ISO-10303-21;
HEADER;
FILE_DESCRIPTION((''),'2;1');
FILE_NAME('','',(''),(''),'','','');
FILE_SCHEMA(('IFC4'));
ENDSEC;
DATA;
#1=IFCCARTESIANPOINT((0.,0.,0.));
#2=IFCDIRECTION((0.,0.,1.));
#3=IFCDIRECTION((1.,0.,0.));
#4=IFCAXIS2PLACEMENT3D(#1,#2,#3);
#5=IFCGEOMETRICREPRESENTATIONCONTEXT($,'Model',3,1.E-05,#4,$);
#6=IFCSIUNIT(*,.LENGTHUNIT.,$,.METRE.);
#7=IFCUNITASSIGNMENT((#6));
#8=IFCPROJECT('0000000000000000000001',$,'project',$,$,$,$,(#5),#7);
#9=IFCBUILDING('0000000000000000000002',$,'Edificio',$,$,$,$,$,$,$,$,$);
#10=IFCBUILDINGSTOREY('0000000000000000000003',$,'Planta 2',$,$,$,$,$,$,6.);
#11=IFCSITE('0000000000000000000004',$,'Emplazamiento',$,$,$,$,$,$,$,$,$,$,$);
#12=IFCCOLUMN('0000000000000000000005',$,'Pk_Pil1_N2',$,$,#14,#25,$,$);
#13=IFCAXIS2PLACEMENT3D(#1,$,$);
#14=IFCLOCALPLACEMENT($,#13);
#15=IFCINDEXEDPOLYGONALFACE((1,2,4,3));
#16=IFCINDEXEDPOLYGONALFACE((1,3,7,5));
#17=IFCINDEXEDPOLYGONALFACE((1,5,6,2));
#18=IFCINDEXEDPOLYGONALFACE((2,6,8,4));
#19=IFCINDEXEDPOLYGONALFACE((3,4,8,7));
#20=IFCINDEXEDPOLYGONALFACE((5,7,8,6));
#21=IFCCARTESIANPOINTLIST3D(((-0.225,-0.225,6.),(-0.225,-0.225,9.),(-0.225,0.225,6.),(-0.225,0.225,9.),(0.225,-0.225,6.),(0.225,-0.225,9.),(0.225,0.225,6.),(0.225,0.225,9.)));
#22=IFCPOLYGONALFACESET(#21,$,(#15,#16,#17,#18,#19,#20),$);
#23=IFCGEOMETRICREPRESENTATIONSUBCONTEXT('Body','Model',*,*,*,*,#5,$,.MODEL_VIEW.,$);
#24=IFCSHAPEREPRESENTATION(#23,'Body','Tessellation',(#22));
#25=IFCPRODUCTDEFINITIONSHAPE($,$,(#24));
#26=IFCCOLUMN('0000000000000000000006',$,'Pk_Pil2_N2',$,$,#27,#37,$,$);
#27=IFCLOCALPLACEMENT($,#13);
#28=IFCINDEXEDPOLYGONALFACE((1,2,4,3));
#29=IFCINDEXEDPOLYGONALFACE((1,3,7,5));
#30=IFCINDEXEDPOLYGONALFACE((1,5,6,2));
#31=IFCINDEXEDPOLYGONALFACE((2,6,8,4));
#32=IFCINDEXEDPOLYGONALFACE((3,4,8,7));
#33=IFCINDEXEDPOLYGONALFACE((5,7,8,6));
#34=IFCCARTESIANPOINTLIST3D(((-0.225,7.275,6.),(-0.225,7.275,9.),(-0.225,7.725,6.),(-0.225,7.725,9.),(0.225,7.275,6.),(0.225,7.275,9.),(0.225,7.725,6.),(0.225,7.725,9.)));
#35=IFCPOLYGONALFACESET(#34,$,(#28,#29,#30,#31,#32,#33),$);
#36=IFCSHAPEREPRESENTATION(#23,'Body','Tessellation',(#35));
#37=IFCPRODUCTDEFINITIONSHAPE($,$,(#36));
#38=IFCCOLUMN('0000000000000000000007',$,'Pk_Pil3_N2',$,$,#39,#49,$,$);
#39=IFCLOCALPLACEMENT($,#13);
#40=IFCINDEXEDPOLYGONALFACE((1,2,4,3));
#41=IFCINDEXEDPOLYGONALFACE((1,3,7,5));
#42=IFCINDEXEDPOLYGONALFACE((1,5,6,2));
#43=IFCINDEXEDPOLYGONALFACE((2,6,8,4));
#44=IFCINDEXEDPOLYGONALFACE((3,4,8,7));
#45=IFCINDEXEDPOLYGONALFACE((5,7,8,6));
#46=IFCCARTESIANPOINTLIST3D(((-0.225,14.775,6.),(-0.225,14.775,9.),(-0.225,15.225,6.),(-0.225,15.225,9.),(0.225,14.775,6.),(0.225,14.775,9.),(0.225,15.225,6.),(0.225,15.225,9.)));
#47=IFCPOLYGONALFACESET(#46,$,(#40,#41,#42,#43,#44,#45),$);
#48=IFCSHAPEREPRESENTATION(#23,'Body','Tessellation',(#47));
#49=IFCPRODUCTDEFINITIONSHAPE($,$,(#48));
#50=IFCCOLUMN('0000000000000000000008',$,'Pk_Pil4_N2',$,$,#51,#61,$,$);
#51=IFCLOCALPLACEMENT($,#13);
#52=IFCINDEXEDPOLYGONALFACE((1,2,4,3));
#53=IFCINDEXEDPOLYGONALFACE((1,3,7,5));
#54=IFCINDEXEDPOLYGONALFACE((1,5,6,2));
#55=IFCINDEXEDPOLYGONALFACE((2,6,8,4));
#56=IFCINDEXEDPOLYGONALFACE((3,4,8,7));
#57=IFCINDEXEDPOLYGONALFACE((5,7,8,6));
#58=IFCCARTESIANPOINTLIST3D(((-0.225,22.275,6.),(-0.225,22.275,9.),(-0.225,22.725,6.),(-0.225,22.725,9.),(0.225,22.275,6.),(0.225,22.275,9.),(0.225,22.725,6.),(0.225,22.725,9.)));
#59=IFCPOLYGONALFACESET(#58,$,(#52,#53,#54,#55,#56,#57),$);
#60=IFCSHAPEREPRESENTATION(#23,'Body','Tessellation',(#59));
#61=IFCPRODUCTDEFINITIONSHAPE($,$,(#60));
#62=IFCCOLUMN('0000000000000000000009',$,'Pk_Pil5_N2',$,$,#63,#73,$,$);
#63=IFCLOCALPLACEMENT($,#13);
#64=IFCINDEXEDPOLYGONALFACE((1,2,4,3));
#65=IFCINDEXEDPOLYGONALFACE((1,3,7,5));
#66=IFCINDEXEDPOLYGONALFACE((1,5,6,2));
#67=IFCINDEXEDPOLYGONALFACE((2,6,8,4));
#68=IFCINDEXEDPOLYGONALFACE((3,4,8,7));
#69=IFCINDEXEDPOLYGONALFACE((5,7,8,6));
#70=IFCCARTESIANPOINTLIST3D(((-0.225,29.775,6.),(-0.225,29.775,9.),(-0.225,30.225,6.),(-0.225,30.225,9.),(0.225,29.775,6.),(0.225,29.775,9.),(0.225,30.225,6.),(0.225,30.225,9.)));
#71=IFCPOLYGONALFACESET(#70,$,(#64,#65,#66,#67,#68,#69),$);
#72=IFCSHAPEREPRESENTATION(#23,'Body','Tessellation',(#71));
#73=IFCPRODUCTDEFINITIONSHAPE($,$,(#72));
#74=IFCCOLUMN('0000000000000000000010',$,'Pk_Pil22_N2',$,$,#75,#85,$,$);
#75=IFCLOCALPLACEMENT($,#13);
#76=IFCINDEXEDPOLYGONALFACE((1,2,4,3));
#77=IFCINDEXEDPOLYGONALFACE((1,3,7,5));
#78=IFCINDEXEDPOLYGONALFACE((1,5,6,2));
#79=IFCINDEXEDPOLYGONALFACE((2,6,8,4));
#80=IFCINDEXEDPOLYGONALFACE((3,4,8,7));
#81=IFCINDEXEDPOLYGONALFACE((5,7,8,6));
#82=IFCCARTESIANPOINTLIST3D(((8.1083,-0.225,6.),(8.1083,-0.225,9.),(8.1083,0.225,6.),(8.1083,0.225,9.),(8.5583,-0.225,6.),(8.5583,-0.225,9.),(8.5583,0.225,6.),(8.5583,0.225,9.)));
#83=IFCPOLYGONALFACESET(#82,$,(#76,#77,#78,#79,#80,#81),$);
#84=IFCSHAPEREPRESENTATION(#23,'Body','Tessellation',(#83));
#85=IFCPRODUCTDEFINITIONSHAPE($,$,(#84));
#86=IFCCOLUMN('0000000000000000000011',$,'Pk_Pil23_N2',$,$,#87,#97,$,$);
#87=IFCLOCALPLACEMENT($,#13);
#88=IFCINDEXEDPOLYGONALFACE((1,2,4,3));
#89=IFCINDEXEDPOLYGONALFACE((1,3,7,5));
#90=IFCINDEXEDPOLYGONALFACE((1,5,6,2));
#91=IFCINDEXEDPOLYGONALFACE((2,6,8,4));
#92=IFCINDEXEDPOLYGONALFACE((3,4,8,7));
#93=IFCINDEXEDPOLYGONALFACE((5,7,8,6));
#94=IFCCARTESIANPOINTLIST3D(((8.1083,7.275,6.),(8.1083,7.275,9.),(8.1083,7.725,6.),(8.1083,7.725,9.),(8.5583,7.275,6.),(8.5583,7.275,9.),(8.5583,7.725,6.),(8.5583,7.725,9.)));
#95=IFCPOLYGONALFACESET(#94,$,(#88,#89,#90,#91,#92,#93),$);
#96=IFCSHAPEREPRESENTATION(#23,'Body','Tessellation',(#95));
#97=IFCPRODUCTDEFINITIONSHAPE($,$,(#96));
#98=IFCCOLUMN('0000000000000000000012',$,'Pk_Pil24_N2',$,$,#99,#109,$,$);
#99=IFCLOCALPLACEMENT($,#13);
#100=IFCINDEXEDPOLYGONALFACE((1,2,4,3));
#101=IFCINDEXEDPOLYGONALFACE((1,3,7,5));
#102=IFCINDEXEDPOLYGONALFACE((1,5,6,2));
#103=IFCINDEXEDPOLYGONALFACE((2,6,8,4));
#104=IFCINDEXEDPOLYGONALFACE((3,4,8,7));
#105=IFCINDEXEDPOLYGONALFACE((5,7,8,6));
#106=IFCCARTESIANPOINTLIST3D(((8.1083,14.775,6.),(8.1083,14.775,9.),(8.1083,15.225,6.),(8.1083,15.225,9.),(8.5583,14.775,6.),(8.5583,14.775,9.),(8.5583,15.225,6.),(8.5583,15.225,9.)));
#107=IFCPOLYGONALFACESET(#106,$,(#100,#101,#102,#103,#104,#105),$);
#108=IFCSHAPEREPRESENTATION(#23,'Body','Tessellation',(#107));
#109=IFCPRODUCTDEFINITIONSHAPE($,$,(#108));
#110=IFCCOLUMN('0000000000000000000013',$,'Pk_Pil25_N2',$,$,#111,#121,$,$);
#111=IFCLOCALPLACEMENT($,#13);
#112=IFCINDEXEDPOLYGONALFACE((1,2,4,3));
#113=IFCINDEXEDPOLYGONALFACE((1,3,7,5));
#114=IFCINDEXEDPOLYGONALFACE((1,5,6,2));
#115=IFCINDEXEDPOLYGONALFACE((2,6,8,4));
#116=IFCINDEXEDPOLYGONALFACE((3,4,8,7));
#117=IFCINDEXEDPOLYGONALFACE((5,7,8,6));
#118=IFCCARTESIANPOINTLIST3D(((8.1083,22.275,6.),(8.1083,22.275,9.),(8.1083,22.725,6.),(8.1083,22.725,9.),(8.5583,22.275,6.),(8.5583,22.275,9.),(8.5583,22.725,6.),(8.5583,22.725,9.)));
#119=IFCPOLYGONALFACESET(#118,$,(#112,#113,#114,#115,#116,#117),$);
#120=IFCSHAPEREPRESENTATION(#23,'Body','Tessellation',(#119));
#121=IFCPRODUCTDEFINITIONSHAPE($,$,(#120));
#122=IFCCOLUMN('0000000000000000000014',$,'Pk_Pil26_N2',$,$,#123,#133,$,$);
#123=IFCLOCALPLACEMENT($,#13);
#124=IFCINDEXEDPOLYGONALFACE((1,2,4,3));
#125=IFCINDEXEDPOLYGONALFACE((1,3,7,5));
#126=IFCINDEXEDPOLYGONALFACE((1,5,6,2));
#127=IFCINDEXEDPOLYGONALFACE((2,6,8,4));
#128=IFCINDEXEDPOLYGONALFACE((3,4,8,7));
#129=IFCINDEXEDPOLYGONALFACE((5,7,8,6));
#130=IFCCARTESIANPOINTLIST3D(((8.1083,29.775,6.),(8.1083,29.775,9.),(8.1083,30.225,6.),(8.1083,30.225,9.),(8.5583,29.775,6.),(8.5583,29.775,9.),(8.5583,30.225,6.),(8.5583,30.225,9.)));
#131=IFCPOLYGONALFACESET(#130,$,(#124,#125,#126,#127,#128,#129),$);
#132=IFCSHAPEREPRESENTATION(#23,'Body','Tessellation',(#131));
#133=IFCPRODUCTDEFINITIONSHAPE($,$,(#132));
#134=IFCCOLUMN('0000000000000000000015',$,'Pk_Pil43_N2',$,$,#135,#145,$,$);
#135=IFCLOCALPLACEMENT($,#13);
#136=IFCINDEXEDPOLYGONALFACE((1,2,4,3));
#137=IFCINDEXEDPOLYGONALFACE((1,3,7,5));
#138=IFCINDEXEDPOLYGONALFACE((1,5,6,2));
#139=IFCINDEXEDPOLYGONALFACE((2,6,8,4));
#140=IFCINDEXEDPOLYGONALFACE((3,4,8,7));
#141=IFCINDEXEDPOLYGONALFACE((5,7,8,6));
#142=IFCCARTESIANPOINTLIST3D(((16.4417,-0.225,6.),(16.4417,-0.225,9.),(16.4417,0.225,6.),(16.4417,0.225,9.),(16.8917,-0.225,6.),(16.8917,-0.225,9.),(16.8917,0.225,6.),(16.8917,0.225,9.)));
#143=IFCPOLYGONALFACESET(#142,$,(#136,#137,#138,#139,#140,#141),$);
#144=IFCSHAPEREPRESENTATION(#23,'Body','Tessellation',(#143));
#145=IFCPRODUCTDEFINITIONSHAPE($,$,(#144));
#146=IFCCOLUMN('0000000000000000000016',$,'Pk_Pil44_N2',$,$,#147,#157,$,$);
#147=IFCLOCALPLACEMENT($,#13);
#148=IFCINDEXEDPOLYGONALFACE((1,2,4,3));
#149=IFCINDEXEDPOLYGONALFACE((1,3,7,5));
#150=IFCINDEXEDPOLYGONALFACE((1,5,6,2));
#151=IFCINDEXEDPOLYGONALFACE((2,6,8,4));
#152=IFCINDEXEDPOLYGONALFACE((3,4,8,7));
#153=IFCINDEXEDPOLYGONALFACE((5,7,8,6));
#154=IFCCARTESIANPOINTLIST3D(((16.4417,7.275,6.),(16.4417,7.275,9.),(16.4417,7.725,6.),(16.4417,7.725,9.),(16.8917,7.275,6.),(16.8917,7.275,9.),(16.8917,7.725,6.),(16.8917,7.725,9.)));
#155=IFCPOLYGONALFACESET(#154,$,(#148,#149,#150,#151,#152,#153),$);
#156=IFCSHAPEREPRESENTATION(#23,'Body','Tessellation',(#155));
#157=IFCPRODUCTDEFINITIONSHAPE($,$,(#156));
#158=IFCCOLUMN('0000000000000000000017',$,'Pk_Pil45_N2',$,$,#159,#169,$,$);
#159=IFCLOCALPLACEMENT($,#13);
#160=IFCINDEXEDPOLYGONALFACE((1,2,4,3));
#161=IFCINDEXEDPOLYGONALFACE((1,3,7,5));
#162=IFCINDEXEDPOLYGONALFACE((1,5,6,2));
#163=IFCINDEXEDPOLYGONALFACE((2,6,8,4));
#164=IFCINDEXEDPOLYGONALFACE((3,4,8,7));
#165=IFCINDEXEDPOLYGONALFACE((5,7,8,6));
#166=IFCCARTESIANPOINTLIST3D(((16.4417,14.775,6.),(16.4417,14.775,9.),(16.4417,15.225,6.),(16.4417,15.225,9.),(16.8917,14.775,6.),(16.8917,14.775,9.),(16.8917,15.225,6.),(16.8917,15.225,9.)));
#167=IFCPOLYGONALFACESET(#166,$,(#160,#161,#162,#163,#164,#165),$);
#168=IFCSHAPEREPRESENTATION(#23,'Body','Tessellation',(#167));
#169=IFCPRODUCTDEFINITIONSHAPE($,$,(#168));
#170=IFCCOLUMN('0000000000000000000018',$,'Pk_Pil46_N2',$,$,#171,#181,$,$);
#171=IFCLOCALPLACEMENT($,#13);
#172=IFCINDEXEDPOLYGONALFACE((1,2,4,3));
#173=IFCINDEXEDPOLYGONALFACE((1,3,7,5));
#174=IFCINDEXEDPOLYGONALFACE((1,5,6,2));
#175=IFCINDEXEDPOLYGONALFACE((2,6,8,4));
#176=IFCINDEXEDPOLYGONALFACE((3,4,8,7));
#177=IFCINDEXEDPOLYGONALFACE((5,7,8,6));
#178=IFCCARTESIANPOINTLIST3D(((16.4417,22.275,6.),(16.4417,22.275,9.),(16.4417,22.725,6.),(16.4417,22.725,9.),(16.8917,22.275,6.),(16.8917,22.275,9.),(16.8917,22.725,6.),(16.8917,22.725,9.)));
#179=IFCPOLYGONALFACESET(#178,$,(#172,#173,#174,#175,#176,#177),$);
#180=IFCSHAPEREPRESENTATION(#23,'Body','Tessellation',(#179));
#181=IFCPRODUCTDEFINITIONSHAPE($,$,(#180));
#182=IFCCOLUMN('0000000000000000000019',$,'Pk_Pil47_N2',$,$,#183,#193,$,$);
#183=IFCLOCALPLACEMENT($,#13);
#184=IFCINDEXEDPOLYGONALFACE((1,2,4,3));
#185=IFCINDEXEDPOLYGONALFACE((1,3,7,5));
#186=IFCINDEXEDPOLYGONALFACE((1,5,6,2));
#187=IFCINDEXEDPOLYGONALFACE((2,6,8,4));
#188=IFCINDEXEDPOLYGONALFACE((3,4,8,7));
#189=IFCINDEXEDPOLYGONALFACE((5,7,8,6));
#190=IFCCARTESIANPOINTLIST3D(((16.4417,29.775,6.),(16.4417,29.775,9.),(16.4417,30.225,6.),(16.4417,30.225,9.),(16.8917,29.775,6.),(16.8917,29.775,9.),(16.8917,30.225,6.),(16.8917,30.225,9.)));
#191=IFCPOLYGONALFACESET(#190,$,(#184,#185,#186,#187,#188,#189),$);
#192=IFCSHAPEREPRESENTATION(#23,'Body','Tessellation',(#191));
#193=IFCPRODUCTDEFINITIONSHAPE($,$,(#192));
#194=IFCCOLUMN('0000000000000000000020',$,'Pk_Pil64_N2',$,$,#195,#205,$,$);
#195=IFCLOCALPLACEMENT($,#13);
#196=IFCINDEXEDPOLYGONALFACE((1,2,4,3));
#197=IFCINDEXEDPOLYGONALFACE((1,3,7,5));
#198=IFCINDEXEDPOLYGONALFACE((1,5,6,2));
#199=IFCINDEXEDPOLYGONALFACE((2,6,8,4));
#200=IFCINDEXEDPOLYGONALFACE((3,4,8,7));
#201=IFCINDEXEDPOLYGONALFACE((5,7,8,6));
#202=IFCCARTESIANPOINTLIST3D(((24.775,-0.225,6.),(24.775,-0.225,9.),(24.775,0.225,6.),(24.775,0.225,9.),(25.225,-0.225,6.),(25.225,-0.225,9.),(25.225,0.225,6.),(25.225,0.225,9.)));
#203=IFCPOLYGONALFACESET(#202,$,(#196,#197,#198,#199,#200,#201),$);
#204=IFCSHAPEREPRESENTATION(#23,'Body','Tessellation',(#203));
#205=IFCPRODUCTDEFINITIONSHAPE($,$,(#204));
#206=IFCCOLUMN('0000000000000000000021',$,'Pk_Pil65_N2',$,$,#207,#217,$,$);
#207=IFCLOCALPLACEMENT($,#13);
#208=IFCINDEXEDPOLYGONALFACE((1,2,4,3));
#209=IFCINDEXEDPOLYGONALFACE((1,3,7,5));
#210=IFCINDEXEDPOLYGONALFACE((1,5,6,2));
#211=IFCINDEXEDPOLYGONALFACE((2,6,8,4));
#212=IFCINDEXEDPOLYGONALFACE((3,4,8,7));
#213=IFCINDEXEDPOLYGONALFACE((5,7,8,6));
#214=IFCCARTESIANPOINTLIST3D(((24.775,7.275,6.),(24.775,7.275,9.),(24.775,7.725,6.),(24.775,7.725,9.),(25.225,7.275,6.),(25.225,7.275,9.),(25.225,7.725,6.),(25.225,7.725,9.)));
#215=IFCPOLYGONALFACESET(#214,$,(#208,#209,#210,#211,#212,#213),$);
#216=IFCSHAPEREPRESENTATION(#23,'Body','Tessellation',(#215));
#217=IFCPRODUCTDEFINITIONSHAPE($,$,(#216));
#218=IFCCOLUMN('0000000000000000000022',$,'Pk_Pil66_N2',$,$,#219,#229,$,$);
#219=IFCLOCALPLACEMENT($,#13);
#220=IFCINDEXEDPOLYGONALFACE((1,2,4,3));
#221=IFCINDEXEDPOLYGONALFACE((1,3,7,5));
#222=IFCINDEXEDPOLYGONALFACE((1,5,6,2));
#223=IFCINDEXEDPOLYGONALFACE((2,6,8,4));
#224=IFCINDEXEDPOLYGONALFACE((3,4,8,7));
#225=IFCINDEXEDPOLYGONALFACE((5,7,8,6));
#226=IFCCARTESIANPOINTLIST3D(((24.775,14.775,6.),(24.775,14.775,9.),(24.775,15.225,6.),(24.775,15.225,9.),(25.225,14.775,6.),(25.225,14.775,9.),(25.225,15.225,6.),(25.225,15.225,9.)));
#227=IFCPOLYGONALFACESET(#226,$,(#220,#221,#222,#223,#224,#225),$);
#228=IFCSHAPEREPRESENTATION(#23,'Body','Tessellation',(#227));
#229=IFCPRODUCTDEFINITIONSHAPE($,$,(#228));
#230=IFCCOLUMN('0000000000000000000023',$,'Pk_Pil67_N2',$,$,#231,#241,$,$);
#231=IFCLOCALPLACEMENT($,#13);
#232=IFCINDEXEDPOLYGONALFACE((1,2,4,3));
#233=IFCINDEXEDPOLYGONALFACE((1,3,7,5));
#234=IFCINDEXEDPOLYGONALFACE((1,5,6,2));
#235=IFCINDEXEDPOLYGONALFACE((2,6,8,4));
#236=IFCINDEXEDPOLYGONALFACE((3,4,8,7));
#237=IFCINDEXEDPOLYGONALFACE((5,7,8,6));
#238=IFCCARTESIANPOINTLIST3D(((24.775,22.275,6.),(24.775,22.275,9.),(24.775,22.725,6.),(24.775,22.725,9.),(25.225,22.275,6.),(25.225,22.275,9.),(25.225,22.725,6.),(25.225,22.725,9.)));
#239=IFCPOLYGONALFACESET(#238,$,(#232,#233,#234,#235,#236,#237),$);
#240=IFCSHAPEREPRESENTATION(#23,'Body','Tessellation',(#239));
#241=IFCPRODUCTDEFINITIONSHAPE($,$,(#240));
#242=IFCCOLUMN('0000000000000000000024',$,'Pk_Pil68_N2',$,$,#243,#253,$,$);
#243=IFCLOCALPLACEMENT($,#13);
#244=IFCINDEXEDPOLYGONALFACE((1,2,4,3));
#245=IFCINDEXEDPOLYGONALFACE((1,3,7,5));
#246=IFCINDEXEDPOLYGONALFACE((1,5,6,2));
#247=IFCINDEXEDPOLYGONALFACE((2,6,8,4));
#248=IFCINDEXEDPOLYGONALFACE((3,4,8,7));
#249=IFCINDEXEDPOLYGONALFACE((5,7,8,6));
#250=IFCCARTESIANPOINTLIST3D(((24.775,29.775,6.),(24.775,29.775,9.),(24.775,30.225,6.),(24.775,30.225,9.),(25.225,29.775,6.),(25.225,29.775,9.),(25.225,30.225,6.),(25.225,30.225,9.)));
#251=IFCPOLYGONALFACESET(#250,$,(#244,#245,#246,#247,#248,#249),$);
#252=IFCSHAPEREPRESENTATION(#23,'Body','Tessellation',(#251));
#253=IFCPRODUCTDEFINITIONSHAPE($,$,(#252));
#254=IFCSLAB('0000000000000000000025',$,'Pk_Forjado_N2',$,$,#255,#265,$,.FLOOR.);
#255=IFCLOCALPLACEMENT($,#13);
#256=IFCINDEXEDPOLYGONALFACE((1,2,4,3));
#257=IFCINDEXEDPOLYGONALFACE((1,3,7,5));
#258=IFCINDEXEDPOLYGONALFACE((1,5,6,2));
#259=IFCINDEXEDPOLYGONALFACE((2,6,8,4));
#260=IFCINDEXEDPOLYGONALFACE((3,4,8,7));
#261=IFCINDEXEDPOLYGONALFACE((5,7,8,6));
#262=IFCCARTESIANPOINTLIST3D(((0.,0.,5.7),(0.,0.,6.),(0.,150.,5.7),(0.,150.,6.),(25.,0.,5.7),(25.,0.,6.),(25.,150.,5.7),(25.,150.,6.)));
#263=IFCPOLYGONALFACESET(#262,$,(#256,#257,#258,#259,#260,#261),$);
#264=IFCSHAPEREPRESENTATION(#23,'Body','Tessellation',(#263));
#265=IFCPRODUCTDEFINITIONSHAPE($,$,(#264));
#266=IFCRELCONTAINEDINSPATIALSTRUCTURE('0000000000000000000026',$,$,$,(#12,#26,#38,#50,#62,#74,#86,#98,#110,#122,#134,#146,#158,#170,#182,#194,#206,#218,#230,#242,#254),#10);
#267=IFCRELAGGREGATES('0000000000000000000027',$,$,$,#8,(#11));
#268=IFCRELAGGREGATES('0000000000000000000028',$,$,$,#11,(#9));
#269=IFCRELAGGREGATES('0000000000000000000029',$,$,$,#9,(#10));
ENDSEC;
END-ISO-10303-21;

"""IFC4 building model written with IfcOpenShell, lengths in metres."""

from ifc_helpers import new_model, si_unit, frame, origin_with_axes, origin_2d, place, context, subcontext, project, spatial, polyline, rectangle, outline, extrude, element, save


model = new_model("IFC4")

# Units and contexts
model_context = context("Model", 3, precision=1e-05, world=origin_with_axes())
body_context = subcontext(model_context, "Body", "Model", "MODEL_VIEW")
ifc_project = project(units=[si_unit("LENGTHUNIT", "METRE")], contexts=[model_context])

# Site, building, storey
site = spatial("IfcSite", under=ifc_project, Name="Emplazamiento")
building = spatial("IfcBuilding", under=site, Name="Edificio")
storey = spatial("IfcBuildingStorey", under=building, Name="Planta 2", Elevation=6.0)

# Columns
for number, where, z_axis, x_axis, name in (
    (1, (0.0, 0.0, 6.0), (0.0, 0.0, 1.0), (1.0, 0.0, 0.0), "Pk_Pil1_N2"),
    (2, (0.0, 7.5, 6.0), (0.0, 0.0, 1.0), (1.0, 0.0, 0.0), "Pk_Pil2_N2"),
    (3, (0.0, 15.0, 6.0), (0.0, 0.0, 1.0), (1.0, 0.0, 0.0), "Pk_Pil3_N2"),
    (4, (0.0, 22.5, 6.0), (0.0, 0.0, 1.0), (1.0, 0.0, 0.0), "Pk_Pil4_N2"),
    (5, (0.0, 30.0, 6.0), (0.0, 0.0, 1.0), (1.0, 0.0, 0.0), "Pk_Pil5_N2"),
    (6, (8.3333, 0.0, 6.0), (0.0, 0.0, 1.0), (1.0, 0.0, 0.0), "Pk_Pil22_N2"),
    (7, (8.3333, 7.5, 6.0), (0.0, 0.0, 1.0), (1.0, 0.0, 0.0), "Pk_Pil23_N2"),
    (8, (8.3333, 15.0, 6.0), (0.0, 0.0, 1.0), (1.0, 0.0, 0.0), "Pk_Pil24_N2"),
    (9, (8.3333, 22.5, 6.0), (0.0, 0.0, 1.0), (1.0, 0.0, 0.0), "Pk_Pil25_N2"),
    (10, (8.3333, 30.0, 6.0), (0.0, 0.0, 1.0), (1.0, 0.0, 0.0), "Pk_Pil26_N2"),
    (11, (16.6667, 0.0, 6.0), (0.0, 0.0, 1.0), (1.0, 0.0, 0.0), "Pk_Pil43_N2"),
    (12, (16.6667, 7.5, 6.0), (0.0, 0.0, 1.0), (1.0, 0.0, 0.0), "Pk_Pil44_N2"),
    (13, (16.6667, 15.0, 6.0), (0.0, 0.0, 1.0), (1.0, 0.0, 0.0), "Pk_Pil45_N2"),
    (14, (16.6667, 22.5, 6.0), (0.0, 0.0, 1.0), (1.0, 0.0, 0.0), "Pk_Pil46_N2"),
    (15, (16.6667, 30.0, 6.0), (0.0, 0.0, 1.0), (1.0, 0.0, 0.0), "Pk_Pil47_N2"),
    (16, (25.0, 0.0, 6.0), (0.0, 0.0, 1.0), (1.0, 0.0, 0.0), "Pk_Pil64_N2"),
    (17, (25.0, 7.5, 6.0), (0.0, 0.0, 1.0), (1.0, 0.0, 0.0), "Pk_Pil65_N2"),
    (18, (25.0, 15.0, 6.0), (0.0, 0.0, 1.0), (1.0, 0.0, 0.0), "Pk_Pil66_N2"),
    (19, (25.0, 22.5, 6.0), (0.0, 0.0, 1.0), (1.0, 0.0, 0.0), "Pk_Pil67_N2"),
    (20, (25.0, 30.0, 6.0), (0.0, 0.0, 1.0), (1.0, 0.0, 0.0), "Pk_Pil68_N2"),
):
    element("IfcColumn", number, at=place(None, frame(where, z_axis=z_axis, x_axis=x_axis)), inside=storey, Name=name, context=body_context, shape_type="SweptSolid", body=[
        extrude(rectangle(XDim=0.45, YDim=0.45, at=origin_2d()), origin_with_axes(), (0.0, 0.0, 1.0), 3.0),
    ])

# Slab
slab_placement = place(None, frame((0.0, 0.0, 6.0), z_axis=(0.0, 0.0, 1.0), x_axis=(1.0, 0.0, 0.0)))
element("IfcSlab", 21, at=slab_placement, inside=storey, Name="Pk_Forjado_N2", PredefinedType="FLOOR", context=body_context, shape_type="SweptSolid", body=[
    extrude(outline(polyline([(0.0, 0.0), (25.0, 0.0), (25.0, 150.0), (0.0, 150.0), (0.0, 0.0)])), frame((0.0, 0.0, -0.3), z_axis=(0.0, 0.0, 1.0), x_axis=(1.0, 0.0, 0.0)), (0.0, 0.0, 1.0), 0.3),
])

save(model, "model.ifc")
